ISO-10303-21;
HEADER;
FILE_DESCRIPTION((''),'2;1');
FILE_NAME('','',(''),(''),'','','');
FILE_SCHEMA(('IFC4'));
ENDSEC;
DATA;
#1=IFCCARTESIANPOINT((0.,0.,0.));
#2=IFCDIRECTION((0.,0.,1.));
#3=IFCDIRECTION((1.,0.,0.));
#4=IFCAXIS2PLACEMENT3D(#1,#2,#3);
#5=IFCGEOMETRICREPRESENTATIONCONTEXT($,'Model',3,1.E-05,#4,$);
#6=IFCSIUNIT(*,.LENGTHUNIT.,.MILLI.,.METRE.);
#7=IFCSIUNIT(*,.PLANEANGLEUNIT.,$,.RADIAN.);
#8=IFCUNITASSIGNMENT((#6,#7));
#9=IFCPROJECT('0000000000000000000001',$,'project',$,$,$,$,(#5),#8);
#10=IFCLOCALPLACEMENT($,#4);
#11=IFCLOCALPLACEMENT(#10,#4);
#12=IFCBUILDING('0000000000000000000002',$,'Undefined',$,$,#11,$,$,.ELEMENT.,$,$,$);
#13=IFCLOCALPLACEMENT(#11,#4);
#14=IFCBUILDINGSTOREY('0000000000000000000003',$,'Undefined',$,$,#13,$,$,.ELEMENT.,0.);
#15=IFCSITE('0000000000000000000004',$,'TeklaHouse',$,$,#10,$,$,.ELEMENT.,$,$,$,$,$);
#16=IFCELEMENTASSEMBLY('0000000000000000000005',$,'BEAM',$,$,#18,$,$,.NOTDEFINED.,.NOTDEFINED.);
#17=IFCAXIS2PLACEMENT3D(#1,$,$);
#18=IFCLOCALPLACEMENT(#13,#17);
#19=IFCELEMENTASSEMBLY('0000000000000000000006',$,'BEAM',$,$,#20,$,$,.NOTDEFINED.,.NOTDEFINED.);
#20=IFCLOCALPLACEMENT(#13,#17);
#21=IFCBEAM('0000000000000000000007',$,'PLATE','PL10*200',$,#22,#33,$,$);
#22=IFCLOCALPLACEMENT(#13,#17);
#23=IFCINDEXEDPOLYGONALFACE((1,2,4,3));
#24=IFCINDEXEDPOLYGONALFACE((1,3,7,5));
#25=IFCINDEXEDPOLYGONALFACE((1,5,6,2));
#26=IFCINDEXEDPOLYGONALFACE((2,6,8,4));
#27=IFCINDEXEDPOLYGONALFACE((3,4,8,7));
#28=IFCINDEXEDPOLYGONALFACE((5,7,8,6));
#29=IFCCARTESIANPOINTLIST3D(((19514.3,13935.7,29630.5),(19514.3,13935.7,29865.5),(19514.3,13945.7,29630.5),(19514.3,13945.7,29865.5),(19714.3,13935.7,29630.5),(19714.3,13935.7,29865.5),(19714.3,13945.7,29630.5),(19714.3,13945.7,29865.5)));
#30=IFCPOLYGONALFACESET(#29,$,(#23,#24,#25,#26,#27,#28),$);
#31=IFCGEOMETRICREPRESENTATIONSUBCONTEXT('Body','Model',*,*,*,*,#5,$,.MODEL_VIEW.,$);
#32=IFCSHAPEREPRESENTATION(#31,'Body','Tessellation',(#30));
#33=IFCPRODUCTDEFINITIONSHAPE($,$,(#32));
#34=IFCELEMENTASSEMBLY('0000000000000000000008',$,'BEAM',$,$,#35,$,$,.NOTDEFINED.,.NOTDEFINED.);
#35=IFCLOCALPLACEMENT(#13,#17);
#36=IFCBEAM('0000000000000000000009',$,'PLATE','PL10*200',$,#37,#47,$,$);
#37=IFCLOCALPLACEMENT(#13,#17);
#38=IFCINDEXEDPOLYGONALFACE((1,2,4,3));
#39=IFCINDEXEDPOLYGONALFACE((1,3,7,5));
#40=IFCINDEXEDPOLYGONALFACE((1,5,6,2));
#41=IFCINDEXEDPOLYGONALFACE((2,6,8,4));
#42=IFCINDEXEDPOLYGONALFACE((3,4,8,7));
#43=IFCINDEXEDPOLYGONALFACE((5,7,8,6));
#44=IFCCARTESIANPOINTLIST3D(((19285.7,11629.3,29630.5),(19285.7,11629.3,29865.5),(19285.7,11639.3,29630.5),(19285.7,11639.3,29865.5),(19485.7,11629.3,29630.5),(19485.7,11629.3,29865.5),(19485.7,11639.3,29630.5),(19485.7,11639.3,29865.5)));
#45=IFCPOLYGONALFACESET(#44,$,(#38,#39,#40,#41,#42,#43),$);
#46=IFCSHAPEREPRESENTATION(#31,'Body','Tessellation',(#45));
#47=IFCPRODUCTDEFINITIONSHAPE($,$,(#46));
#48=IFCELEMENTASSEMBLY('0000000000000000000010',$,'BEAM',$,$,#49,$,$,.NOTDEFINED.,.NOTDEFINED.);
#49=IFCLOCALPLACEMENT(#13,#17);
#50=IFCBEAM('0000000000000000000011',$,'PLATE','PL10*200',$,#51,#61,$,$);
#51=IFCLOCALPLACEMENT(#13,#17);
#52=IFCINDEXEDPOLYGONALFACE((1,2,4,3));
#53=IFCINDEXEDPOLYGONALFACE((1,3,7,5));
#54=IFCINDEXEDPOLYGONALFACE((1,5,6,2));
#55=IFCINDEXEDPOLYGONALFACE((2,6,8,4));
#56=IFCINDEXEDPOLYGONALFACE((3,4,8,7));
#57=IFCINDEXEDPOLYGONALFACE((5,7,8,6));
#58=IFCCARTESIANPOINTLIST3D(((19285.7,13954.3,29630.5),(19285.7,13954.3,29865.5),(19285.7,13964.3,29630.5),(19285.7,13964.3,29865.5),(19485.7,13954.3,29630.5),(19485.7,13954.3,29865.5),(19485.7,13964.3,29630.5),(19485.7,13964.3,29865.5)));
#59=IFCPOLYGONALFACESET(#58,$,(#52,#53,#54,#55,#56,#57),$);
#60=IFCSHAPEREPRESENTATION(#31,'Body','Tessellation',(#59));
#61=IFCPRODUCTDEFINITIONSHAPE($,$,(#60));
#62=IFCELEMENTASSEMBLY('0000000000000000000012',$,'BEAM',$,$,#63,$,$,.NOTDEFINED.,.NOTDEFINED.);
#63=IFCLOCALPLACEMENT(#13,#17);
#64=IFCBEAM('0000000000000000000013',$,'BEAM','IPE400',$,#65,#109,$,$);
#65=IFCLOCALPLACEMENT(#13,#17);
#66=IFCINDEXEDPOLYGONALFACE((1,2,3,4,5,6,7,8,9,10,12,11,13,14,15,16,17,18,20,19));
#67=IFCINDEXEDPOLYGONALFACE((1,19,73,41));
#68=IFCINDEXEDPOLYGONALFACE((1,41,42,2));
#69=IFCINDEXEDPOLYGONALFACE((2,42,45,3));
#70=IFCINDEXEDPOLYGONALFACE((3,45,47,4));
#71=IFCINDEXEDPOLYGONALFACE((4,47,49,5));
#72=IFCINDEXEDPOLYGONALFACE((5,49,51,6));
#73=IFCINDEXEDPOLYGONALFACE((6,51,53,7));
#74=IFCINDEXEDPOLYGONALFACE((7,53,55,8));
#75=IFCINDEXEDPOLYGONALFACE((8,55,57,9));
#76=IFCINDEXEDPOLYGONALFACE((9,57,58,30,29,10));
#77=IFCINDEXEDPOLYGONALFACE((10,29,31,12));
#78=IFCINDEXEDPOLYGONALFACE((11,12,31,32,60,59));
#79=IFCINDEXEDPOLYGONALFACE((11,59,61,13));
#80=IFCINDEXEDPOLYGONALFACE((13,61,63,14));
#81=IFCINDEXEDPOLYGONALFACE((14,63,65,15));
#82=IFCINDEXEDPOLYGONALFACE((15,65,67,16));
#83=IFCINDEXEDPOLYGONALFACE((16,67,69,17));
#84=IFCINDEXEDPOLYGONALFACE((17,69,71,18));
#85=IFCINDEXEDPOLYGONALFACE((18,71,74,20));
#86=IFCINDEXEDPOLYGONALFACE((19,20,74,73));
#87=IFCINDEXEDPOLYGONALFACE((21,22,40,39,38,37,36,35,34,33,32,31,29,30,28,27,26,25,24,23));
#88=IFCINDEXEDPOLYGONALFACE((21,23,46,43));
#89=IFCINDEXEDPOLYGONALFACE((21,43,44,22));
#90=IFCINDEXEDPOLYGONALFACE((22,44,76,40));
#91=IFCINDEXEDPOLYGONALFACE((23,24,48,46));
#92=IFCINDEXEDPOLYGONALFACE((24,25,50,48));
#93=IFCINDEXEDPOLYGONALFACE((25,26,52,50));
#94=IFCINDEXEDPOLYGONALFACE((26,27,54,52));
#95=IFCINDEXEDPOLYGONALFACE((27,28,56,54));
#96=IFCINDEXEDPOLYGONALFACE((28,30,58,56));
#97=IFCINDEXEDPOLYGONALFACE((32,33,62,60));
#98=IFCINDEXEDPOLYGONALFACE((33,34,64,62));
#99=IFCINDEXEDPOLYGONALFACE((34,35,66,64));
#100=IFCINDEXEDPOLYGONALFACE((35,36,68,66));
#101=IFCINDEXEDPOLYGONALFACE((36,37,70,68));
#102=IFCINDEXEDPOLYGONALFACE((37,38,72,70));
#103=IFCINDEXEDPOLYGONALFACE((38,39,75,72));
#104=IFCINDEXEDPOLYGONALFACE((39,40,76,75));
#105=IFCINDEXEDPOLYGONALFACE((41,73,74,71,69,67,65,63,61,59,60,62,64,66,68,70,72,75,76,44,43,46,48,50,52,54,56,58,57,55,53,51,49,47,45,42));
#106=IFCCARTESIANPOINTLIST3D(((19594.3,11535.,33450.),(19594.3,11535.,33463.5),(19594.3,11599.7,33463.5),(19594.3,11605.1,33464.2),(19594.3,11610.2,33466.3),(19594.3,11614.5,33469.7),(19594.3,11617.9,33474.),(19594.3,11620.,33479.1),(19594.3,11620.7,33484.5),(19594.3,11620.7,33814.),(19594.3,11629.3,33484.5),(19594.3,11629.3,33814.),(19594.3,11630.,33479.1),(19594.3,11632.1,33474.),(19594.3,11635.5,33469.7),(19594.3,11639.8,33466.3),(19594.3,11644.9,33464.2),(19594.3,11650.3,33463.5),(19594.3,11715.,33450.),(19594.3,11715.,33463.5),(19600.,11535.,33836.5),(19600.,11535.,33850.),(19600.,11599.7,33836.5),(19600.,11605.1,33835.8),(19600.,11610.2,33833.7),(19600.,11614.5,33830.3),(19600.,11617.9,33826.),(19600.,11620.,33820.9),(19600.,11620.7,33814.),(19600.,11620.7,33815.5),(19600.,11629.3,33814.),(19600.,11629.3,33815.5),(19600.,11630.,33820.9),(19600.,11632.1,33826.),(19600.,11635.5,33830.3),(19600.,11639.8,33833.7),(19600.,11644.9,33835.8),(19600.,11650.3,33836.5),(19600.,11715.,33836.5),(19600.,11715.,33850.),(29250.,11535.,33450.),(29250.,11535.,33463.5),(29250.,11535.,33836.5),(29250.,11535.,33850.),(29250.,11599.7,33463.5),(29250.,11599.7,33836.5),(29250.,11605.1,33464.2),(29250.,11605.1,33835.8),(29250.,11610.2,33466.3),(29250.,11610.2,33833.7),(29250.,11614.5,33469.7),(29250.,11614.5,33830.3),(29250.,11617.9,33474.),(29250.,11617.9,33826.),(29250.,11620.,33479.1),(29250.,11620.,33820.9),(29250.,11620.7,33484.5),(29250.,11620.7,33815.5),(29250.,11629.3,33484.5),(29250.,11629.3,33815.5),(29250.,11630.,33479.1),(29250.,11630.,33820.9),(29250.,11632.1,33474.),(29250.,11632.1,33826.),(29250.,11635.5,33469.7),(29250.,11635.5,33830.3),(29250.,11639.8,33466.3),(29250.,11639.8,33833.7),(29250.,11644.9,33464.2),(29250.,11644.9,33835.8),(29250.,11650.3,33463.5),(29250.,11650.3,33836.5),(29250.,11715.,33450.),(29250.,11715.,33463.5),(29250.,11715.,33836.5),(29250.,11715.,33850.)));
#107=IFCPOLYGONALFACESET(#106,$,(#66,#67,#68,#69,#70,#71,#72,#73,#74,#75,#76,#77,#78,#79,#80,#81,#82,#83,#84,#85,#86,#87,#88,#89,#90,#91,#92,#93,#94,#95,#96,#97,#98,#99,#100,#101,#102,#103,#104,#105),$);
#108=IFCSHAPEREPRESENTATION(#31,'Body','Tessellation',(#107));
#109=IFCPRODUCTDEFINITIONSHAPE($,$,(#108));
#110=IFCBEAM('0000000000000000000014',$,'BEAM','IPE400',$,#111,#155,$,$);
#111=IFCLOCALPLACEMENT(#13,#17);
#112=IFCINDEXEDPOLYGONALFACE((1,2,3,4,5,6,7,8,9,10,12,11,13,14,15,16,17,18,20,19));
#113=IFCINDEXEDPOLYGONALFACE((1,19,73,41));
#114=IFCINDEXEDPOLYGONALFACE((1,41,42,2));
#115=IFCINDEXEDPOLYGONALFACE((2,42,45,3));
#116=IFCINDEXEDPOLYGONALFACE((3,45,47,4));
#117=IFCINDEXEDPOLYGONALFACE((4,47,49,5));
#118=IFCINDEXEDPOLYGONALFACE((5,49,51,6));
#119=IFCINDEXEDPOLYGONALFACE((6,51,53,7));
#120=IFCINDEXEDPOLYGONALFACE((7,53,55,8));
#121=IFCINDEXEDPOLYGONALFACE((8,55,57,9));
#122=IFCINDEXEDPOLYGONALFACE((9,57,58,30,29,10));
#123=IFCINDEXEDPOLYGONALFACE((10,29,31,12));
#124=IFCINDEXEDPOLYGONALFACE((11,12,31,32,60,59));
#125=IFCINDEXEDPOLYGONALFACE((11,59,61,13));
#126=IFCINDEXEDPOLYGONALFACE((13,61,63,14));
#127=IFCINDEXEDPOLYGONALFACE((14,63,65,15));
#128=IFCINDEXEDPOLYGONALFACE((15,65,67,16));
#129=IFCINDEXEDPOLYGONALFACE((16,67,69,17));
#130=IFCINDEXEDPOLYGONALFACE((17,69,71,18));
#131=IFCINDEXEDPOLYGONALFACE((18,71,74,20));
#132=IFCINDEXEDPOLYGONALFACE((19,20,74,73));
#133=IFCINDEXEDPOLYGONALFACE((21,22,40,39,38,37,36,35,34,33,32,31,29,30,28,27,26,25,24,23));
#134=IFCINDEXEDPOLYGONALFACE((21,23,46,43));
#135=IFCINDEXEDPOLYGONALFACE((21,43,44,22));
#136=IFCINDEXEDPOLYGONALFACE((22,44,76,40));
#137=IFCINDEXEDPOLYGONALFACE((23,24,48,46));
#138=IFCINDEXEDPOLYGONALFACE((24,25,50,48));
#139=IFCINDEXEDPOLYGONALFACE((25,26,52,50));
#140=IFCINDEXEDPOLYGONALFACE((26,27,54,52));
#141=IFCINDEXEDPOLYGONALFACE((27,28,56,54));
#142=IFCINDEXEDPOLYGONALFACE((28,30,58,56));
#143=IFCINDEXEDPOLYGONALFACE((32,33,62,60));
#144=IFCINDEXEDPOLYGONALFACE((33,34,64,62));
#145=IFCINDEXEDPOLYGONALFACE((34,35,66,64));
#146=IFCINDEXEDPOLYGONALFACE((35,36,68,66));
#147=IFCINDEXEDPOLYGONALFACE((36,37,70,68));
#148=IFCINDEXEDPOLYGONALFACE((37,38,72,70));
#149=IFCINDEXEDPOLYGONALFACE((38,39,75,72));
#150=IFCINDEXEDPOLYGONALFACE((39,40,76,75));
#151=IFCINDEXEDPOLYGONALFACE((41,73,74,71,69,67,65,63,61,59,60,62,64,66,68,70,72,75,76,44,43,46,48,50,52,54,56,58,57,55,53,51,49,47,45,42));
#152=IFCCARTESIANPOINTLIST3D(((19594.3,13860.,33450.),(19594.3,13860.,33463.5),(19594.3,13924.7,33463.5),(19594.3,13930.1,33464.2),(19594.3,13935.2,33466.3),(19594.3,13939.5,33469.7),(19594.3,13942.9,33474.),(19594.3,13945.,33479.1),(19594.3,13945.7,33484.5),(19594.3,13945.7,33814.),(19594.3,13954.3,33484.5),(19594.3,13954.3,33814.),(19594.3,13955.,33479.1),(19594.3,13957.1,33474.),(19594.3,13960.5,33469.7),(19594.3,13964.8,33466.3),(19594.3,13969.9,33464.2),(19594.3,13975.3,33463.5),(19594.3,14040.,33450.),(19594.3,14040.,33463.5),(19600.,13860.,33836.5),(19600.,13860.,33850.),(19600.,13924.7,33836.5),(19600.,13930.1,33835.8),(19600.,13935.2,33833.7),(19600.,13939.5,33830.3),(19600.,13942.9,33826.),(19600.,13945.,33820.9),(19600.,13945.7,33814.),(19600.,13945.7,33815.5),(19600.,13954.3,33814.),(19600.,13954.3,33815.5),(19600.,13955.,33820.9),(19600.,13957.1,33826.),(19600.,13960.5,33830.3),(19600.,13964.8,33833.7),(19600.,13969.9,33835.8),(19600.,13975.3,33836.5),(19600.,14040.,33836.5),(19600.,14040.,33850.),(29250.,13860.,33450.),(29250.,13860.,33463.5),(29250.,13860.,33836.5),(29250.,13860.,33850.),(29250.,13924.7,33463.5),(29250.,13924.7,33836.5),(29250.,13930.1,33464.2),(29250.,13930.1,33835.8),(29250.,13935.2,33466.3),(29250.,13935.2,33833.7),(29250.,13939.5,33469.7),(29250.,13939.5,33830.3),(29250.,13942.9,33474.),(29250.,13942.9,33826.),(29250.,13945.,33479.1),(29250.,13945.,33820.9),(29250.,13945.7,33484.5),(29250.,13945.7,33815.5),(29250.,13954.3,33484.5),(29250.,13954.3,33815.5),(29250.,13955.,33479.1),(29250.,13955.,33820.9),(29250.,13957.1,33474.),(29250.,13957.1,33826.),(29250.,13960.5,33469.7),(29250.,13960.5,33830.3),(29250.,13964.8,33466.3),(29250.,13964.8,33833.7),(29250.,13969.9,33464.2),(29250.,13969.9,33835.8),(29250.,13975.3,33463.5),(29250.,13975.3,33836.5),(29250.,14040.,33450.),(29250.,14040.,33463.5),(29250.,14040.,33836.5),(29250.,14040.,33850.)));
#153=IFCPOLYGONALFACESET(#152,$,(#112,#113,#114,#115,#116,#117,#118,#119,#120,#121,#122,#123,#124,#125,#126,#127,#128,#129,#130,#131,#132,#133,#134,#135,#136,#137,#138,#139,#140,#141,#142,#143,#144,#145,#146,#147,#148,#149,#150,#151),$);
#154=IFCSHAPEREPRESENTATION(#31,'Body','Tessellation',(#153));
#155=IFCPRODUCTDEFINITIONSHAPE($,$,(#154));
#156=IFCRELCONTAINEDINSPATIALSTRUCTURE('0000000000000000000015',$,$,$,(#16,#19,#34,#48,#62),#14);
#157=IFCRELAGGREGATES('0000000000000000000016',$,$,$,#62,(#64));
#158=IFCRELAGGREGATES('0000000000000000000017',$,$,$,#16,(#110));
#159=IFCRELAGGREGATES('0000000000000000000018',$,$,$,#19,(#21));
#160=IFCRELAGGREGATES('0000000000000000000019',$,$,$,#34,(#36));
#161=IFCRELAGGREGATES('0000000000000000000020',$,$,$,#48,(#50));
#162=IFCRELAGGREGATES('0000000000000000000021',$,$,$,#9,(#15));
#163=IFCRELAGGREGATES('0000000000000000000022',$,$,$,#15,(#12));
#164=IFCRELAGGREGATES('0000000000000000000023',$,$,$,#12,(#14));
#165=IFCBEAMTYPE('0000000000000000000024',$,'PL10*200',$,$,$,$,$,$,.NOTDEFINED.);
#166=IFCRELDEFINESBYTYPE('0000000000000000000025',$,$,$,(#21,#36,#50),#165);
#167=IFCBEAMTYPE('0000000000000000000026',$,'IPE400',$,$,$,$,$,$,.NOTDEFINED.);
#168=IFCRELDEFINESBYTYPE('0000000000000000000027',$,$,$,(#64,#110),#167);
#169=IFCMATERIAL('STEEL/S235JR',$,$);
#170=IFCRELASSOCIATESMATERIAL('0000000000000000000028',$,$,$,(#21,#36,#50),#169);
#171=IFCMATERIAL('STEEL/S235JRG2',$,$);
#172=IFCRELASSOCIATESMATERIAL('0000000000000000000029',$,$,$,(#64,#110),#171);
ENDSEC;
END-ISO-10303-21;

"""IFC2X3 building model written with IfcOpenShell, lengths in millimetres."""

from ifc_helpers import new_model, si_unit, frame, origin_with_axes, origin_2d_with_axis, place, context, subcontext, project, spatial, polyline, rectangle, i_section, outline, extrude, boolean, halfspace, material, type_object, element, aggregate, save


model = new_model("IFC2X3")

# Units and contexts
model_context = context("Model", 3, precision=1e-05, world=origin_with_axes())
body_context = subcontext(model_context, "Body", "Model", "MODEL_VIEW")
ifc_project = project(units=[si_unit("LENGTHUNIT", "METRE", prefix="MILLI"), si_unit("PLANEANGLEUNIT", "RADIAN")], contexts=[model_context])

# Site, building, storey
site_placement = place(None, origin_with_axes())
site = spatial("IfcSite", under=ifc_project, at=site_placement, Name="TeklaHouse", CompositionType="ELEMENT")
building_placement = place(site_placement, origin_with_axes())
building = spatial("IfcBuilding", under=site, at=building_placement, Name="Undefined", CompositionType="ELEMENT")
storey_placement = place(building_placement, origin_with_axes())
storey = spatial("IfcBuildingStorey", under=building, at=storey_placement, Name="Undefined", CompositionType="ELEMENT", Elevation=0.0)

# Shared definitions
ifc_material_1 = material(Name="STEEL/S235JRG2")

# Element assemblies, beams
ifc_material_2 = material(Name="STEEL/S235JR")
assembly_1_placement = place(storey_placement, origin_with_axes())
assembly_1 = element("IfcElementAssembly", 1, at=assembly_1_placement, inside=storey, Name="BEAM", AssemblyPlace="NOTDEFINED", PredefinedType="NOTDEFINED")
beam_type_1 = type_object("IfcBeamType", Name="PL10*200", PredefinedType="NOTDEFINED")
assembly_2_placement = place(storey_placement, origin_with_axes())
assembly_2 = element("IfcElementAssembly", 2, at=assembly_2_placement, inside=storey, Name="BEAM", AssemblyPlace="NOTDEFINED", PredefinedType="NOTDEFINED")
beam_1_placement = place(assembly_2_placement, frame((19614.3, 13940.7, 29630.5), z_axis=(-1.0, 0.0, 0.0), x_axis=(0.0, 0.0, 1.0)))
beam_1 = element("IfcBeam", 3, at=beam_1_placement, type_object=beam_type_1, material=ifc_material_2, Name="PLATE", Description="PL10*200", context=body_context, shape_type="SweptSolid", body=[
    extrude(rectangle(XDim=10.0, YDim=200.0, at=origin_2d_with_axis()), frame((235.0, 0.0, 0.0), z_axis=(-1.0, 0.0, 0.0), x_axis=(0.0, -1.0, 0.0)), (0.0, 0.0, 1.0), 235.0),
])
assembly_3_placement = place(storey_placement, origin_with_axes())
assembly_3 = element("IfcElementAssembly", 4, at=assembly_3_placement, inside=storey, Name="BEAM", AssemblyPlace="NOTDEFINED", PredefinedType="NOTDEFINED")
beam_2_placement = place(assembly_3_placement, frame((19385.7, 11634.3, 29630.5), z_axis=(1.0, 0.0, 0.0), x_axis=(0.0, 0.0, 1.0)))
beam_2 = element("IfcBeam", 5, at=beam_2_placement, type_object=beam_type_1, material=ifc_material_2, Name="PLATE", Description="PL10*200", context=body_context, shape_type="SweptSolid", body=[
    extrude(rectangle(XDim=10.0, YDim=200.0, at=origin_2d_with_axis()), frame((235.0, 0.0, 0.0), z_axis=(-1.0, 0.0, 0.0), x_axis=(0.0, -1.0, 0.0)), (0.0, 0.0, 1.0), 235.0),
])
assembly_4_placement = place(storey_placement, origin_with_axes())
assembly_4 = element("IfcElementAssembly", 6, at=assembly_4_placement, inside=storey, Name="BEAM", AssemblyPlace="NOTDEFINED", PredefinedType="NOTDEFINED")
beam_3_placement = place(assembly_4_placement, frame((19385.7, 13959.3, 29630.5), z_axis=(1.0, 0.0, 0.0), x_axis=(0.0, 0.0, 1.0)))
beam_3 = element("IfcBeam", 7, at=beam_3_placement, type_object=beam_type_1, material=ifc_material_2, Name="PLATE", Description="PL10*200", context=body_context, shape_type="SweptSolid", body=[
    extrude(rectangle(XDim=10.0, YDim=200.0, at=origin_2d_with_axis()), frame((235.0, 0.0, 0.0), z_axis=(-1.0, 0.0, 0.0), x_axis=(0.0, -1.0, 0.0)), (0.0, 0.0, 1.0), 235.0),
])
assembly_5_placement = place(storey_placement, origin_with_axes())
assembly_5 = element("IfcElementAssembly", 8, at=assembly_5_placement, inside=storey, Name="BEAM", AssemblyPlace="NOTDEFINED", PredefinedType="NOTDEFINED")
beam_type_2 = type_object("IfcBeamType", Name="IPE400", PredefinedType="NOTDEFINED")
beam_4_placement = place(assembly_5_placement, frame((19500.0, 11625.0, 33650.0), z_axis=(0.0, 0.0, 1.0), x_axis=(1.0, 0.0, 0.0)))
beam_4 = element("IfcBeam", 9, at=beam_4_placement, type_object=beam_type_2, material=ifc_material_1, Name="BEAM", Description="IPE400", context=body_context, shape_type="CSG", body=[
    boolean("DIFFERENCE", boolean("DIFFERENCE", boolean("DIFFERENCE", extrude(i_section(OverallWidth=180.0, OverallDepth=400.0, WebThickness=8.6, FlangeThickness=13.5, FilletRadius=21.0, at=origin_2d_with_axis()), frame((9750.0, 0.0, 0.0), z_axis=(-1.0, 0.0, 0.0), x_axis=(0.0, -1.0, 0.0)), (0.0, 0.0, 1.0), 9750.0), extrude(outline(polyline([(0.0, 0.0), (95.7, 0.0), (95.7, 23.5), (0.0, 23.5), (0.0, 0.0)])), frame((-5.7, -100.0, -186.5), z_axis=(0.0, 1.0, 0.0), x_axis=(1.0, 0.0, 0.0)), (0.0, 0.0, 1.0), 200.0)), extrude(outline(polyline([(0.0, 0.0), (105.7, 0.0), (105.7, 46.0), (0.0, 46.0), (0.0, 0.0)])), frame((-5.7, 100.0, 164.0), z_axis=(0.0, -1.0, 0.0), x_axis=(1.0, 0.0, 0.0)), (0.0, 0.0, 1.0), 200.0)), halfspace(frame((94.3, 0.0, 0.0), z_axis=(1.0, 0.0, 0.0), x_axis=(0.0, -1.0, 0.0)), True)),
])

# Beam
beam_5_placement = place(assembly_1_placement, frame((19500.0, 13950.0, 33650.0), z_axis=(0.0, 0.0, 1.0), x_axis=(1.0, 0.0, 0.0)))
beam_5 = element("IfcBeam", 10, at=beam_5_placement, type_object=beam_type_2, material=ifc_material_1, Name="BEAM", Description="IPE400", context=body_context, shape_type="CSG", body=[
    boolean("DIFFERENCE", boolean("DIFFERENCE", boolean("DIFFERENCE", extrude(i_section(OverallWidth=180.0, OverallDepth=400.0, WebThickness=8.6, FlangeThickness=13.5, FilletRadius=21.0, at=origin_2d_with_axis()), frame((9750.0, 0.0, 0.0), z_axis=(-1.0, 0.0, 0.0), x_axis=(0.0, -1.0, 0.0)), (0.0, 0.0, 1.0), 9750.0), extrude(outline(polyline([(0.0, 0.0), (95.7, 0.0), (95.7, 23.5), (0.0, 23.5), (0.0, 0.0)])), frame((-5.7, -100.0, -186.5), z_axis=(0.0, 1.0, 0.0), x_axis=(1.0, 0.0, 0.0)), (0.0, 0.0, 1.0), 200.0)), extrude(outline(polyline([(0.0, 0.0), (105.7, 0.0), (105.7, 46.0), (0.0, 46.0), (0.0, 0.0)])), frame((-5.7, 100.0, 164.0), z_axis=(0.0, -1.0, 0.0), x_axis=(1.0, 0.0, 0.0)), (0.0, 0.0, 1.0), 200.0)), halfspace(frame((94.3, 0.0, 0.0), z_axis=(1.0, 0.0, 0.0), x_axis=(0.0, -1.0, 0.0)), True)),
])

aggregate(assembly_5, [beam_4])
aggregate(assembly_1, [beam_5])
aggregate(assembly_2, [beam_1])
aggregate(assembly_3, [beam_2])
aggregate(assembly_4, [beam_3])

save(model, "model.ifc")
